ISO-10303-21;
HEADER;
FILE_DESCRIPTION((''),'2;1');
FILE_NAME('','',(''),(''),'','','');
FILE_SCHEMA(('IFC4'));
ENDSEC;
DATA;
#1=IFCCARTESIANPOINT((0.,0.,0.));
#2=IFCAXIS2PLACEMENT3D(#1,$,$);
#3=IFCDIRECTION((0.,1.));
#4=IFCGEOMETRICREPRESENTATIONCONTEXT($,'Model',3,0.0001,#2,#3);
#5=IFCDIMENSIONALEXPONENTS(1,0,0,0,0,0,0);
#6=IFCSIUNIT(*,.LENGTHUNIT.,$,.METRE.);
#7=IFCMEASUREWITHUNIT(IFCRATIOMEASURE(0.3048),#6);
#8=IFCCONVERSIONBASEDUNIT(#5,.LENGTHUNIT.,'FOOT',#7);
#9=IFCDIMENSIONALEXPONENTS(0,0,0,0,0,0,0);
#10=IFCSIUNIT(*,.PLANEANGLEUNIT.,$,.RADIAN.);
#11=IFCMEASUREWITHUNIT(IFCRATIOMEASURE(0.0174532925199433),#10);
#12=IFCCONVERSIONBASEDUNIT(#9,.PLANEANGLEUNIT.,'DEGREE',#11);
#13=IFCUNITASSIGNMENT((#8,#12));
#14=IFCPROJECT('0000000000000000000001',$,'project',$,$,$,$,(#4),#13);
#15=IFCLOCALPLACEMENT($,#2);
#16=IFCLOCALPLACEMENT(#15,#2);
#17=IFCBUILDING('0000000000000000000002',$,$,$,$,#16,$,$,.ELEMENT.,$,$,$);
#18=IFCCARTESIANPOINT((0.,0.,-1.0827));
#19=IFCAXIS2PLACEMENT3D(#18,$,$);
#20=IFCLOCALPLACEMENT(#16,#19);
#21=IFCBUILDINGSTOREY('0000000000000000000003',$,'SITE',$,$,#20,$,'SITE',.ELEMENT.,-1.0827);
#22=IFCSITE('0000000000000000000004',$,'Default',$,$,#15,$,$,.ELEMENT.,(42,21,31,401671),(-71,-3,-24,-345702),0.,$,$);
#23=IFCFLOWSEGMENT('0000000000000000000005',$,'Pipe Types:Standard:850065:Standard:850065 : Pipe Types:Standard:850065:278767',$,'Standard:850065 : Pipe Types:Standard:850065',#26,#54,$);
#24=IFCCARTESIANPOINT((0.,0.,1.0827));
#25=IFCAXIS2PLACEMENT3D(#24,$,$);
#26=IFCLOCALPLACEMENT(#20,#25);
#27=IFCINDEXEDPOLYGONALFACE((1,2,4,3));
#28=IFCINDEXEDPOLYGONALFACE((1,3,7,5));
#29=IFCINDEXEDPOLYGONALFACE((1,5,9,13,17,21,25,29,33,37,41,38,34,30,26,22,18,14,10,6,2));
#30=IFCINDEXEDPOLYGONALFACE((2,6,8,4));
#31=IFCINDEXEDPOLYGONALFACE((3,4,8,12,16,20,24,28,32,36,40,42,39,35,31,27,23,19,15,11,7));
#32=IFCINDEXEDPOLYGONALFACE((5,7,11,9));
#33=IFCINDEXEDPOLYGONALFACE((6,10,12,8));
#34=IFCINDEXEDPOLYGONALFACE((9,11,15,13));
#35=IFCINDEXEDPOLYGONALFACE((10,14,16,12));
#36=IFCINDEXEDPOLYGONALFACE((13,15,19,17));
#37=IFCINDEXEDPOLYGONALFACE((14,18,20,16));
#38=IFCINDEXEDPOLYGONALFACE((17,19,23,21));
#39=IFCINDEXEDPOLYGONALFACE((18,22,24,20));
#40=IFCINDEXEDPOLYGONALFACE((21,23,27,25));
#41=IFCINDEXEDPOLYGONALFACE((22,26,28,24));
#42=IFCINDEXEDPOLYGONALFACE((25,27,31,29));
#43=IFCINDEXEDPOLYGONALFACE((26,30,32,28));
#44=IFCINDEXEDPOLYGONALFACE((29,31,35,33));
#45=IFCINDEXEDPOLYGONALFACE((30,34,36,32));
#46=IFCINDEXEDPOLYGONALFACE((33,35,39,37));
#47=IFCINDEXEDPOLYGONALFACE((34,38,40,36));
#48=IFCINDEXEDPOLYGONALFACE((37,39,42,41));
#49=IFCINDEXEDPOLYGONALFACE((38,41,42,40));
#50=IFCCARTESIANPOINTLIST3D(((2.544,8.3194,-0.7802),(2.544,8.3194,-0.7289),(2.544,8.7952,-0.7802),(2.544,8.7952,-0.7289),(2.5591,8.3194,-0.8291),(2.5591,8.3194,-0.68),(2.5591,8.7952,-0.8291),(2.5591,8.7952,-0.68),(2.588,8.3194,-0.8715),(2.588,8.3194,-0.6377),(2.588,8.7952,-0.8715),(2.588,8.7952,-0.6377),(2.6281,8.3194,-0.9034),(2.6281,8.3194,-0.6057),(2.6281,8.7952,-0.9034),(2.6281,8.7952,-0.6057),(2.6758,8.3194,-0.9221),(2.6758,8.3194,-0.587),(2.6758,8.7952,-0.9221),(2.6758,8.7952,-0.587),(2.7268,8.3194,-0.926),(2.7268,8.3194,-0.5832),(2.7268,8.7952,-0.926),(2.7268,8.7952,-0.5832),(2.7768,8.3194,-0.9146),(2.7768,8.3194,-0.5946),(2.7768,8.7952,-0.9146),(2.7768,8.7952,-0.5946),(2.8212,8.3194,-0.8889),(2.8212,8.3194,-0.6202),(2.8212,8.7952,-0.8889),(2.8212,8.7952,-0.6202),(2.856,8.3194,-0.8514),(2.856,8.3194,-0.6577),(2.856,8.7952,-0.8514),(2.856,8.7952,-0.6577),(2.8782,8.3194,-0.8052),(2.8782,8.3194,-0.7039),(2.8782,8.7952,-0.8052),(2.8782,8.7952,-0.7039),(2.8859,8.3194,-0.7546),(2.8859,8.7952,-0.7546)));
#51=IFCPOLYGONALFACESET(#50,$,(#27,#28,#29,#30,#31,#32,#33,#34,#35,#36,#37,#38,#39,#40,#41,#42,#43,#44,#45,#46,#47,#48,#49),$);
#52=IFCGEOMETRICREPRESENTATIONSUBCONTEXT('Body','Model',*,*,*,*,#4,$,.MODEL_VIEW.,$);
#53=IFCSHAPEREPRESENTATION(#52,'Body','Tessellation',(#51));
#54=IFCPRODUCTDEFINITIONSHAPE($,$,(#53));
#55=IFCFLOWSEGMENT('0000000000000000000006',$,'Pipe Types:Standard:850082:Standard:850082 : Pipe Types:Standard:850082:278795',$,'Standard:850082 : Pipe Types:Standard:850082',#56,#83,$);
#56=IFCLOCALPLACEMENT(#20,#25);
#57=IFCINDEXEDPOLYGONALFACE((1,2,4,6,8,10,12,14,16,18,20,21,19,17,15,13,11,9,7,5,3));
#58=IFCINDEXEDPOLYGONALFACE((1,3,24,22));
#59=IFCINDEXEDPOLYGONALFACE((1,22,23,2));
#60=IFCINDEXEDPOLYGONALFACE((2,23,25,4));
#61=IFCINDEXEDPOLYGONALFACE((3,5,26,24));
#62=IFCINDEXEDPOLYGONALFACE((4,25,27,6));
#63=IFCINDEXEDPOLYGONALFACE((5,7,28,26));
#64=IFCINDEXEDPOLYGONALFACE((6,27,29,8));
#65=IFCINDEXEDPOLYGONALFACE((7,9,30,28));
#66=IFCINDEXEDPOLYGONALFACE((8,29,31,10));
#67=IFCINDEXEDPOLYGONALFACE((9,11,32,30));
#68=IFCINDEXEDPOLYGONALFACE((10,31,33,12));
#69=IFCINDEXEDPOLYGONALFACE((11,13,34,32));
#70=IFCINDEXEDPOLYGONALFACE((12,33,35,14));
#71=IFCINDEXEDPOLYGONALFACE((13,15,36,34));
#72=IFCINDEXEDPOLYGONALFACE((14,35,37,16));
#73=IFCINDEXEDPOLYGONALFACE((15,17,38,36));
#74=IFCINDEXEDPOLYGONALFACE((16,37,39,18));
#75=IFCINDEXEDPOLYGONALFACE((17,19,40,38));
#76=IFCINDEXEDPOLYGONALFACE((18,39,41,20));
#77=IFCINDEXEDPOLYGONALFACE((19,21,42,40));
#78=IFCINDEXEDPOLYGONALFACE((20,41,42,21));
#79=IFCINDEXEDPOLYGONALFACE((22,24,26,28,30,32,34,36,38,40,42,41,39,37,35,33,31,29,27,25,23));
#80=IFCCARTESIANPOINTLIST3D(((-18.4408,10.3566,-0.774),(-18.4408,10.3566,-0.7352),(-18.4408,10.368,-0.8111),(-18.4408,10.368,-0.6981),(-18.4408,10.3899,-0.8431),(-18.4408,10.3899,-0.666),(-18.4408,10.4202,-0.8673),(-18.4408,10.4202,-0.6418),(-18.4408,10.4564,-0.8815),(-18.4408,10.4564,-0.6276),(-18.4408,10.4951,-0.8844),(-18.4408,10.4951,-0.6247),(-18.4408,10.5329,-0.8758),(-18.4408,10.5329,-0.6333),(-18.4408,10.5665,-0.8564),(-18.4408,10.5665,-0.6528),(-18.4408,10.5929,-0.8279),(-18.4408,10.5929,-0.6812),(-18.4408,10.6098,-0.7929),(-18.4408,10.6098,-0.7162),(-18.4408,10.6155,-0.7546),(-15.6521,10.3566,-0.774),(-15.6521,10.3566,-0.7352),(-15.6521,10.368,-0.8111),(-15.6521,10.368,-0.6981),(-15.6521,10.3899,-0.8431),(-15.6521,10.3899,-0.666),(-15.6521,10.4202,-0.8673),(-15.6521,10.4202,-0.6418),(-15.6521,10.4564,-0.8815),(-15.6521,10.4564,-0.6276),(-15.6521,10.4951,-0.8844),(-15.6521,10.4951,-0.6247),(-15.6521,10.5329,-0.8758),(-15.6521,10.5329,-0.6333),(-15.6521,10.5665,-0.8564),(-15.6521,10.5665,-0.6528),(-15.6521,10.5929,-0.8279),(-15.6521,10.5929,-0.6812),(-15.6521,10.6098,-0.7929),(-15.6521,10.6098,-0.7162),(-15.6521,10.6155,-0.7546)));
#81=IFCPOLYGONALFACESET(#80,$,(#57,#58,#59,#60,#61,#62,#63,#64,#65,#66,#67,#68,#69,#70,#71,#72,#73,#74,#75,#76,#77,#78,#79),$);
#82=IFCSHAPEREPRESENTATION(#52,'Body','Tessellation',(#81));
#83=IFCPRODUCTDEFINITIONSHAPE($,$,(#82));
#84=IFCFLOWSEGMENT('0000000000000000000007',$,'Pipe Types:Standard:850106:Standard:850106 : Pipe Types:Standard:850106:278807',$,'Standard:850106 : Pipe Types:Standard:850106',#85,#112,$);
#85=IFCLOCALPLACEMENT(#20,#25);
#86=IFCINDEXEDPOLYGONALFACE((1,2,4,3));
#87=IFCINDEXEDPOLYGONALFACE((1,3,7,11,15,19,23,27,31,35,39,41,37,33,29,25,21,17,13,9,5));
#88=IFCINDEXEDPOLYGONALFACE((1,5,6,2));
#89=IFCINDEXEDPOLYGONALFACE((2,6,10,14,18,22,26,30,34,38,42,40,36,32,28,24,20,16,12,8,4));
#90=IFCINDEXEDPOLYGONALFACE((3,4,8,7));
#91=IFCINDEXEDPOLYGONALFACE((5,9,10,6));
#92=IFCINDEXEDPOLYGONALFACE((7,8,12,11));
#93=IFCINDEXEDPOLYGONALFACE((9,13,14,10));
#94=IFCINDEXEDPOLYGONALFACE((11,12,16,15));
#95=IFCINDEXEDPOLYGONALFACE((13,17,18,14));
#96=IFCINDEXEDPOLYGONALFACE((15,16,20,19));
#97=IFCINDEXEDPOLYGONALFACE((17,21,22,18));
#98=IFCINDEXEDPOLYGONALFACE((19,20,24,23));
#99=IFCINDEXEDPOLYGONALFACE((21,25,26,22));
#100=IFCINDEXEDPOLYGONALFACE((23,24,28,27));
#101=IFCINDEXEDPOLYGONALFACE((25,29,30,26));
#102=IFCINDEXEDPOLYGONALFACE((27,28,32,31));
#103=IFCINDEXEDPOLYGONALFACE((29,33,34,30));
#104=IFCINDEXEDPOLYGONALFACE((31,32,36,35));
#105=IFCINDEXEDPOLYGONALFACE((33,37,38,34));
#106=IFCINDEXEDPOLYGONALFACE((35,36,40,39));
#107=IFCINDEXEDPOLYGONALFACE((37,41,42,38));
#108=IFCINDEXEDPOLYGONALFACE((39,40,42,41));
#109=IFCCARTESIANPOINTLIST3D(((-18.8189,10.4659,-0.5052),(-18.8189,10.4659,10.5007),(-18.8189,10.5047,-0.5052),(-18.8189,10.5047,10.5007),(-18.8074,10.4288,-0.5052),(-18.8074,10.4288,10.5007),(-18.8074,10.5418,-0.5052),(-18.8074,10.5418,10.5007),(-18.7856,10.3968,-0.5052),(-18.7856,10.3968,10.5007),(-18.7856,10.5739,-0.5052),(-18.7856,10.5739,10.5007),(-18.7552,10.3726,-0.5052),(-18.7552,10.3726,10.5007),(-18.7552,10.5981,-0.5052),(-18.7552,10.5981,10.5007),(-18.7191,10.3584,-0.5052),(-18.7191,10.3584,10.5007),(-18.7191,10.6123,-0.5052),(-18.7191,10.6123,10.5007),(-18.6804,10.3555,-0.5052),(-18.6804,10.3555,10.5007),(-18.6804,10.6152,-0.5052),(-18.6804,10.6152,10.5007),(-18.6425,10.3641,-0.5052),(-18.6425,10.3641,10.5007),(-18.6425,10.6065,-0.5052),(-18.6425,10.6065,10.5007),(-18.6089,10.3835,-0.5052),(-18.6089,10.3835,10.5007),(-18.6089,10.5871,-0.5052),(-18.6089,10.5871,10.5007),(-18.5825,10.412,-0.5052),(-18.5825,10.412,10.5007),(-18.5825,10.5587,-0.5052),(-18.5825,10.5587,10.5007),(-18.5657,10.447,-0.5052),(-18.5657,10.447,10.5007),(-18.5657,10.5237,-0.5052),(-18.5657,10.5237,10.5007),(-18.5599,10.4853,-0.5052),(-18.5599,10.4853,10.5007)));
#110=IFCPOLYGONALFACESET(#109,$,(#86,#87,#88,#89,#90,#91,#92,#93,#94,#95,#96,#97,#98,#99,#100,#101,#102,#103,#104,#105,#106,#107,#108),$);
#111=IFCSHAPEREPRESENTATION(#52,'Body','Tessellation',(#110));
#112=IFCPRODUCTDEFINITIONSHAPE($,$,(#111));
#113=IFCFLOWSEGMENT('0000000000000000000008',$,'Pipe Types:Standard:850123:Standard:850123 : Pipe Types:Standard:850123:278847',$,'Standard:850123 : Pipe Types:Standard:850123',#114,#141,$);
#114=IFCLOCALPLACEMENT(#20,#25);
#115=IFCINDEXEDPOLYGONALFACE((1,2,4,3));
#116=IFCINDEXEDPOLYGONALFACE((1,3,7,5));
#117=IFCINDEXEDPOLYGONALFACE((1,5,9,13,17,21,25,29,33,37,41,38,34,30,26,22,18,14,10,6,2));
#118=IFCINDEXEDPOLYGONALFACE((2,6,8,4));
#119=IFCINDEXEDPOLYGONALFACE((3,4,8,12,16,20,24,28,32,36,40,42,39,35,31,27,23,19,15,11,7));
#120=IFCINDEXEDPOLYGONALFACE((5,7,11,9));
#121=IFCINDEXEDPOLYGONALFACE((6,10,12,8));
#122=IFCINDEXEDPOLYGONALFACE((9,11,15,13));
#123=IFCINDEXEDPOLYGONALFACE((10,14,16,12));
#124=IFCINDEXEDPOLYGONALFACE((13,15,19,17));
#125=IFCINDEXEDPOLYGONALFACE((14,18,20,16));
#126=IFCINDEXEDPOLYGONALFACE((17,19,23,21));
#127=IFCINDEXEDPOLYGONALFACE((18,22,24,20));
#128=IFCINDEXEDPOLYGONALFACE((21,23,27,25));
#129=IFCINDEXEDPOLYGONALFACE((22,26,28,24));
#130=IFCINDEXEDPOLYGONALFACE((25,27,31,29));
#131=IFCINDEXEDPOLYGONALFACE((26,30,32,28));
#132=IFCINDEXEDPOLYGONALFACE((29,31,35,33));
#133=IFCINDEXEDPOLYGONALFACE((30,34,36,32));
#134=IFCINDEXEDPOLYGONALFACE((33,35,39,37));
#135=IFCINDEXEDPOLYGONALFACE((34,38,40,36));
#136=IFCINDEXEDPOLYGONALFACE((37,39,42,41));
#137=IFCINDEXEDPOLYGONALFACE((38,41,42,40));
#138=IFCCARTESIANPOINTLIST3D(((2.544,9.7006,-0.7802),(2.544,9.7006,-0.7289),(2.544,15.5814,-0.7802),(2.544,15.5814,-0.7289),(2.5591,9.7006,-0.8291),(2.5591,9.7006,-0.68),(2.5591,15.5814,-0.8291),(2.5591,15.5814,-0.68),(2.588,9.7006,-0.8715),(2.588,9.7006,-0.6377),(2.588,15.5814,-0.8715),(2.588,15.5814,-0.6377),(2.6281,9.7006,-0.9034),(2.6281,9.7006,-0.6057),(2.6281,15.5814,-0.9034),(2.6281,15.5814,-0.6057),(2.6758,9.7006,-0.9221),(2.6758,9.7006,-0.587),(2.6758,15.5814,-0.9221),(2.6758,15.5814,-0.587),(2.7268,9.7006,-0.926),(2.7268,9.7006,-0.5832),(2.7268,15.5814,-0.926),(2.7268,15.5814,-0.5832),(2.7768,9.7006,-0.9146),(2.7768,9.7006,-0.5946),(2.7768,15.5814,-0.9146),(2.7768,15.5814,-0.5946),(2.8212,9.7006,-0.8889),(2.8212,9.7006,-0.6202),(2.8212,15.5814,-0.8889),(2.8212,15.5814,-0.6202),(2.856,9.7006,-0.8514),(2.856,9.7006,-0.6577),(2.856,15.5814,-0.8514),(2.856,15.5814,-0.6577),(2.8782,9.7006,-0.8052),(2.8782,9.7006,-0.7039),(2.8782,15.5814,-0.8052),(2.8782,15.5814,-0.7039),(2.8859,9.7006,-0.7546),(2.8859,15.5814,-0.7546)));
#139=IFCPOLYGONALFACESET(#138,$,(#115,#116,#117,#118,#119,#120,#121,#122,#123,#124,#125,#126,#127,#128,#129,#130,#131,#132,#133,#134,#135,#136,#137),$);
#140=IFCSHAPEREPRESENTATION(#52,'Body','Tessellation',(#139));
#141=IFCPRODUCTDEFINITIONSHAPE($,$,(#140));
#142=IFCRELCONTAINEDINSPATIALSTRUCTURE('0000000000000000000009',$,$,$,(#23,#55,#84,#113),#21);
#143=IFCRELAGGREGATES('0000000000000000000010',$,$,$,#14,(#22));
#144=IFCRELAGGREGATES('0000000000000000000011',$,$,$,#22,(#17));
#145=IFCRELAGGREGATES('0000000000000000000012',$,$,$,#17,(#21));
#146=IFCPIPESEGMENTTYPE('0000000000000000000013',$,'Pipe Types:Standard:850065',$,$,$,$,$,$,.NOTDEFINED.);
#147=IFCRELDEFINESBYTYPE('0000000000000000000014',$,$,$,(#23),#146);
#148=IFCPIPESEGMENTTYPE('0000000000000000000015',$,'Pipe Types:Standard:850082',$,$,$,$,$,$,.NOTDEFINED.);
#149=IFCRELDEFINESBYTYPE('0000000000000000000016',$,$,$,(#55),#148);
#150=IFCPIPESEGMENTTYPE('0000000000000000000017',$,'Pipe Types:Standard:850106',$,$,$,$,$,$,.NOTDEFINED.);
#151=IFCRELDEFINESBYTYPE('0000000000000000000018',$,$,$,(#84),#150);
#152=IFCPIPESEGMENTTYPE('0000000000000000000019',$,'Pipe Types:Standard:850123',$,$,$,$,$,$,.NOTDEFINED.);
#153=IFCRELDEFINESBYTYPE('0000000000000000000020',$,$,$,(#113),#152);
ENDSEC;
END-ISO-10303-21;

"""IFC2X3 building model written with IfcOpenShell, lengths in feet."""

from ifc_helpers import new_model, entity, si_unit, converted_unit, direction, frame, frame_2d, origin, origin_2d_with_axis, place, context, subcontext, project, spatial, circle, extrude, source, transform, mapped, type_object, type_shapes, element, save


model = new_model("IFC2X3")

# Units and contexts
model_context = context("Model", 3, precision=0.0001, world=origin(), true_north=direction((0.0, 1.0)))
body_context = subcontext(model_context, "Body", "Model", "MODEL_VIEW")
ifc_project = project(units=[converted_unit("LENGTHUNIT", "FOOT", entity("IfcRatioMeasure", 0.3048), si_unit("LENGTHUNIT", "METRE"), dimensions=[1, 0, 0, 0, 0, 0, 0]), converted_unit("PLANEANGLEUNIT", "DEGREE", entity("IfcRatioMeasure", 0.0174532925199433), si_unit("PLANEANGLEUNIT", "RADIAN"), dimensions=[0, 0, 0, 0, 0, 0, 0])], contexts=[model_context])

# Site, building, storey
site_placement = place(None, origin())
site = spatial("IfcSite", under=ifc_project, at=site_placement, Name="Default", CompositionType="ELEMENT", RefLatitude=(42, 21, 31, 401671), RefLongitude=(-71, -3, -24, -345702), RefElevation=0.0)
building_placement = place(site_placement, origin())
building = spatial("IfcBuilding", under=site, at=building_placement, CompositionType="ELEMENT")
storey_placement = place(building_placement, frame((0.0, 0.0, -1.0827)))
storey = spatial("IfcBuildingStorey", under=building, at=storey_placement, Name="SITE", LongName="SITE", CompositionType="ELEMENT", Elevation=-1.0827)

# Flow segments
pipe_segment_type_1 = type_object("IfcPipeSegmentType", Name="Pipe Types:Standard:850065", PredefinedType="NOTDEFINED")
shared_shape_1 = source(origin(), body_context, "Body", "SweptSolid", [
    extrude(circle(Radius=0.1719, at=frame_2d((0.0, 0.0), x_axis=(1.0, 0.0))), frame((2.714, 8.3194, -0.7546), z_axis=(0.0, 1.0, 0.0), x_axis=(1.0, 0.0, 0.0)), (0.0, 0.0, 1.0), 0.4759),
])
type_shapes(pipe_segment_type_1, [shared_shape_1])
flow_segment_1_placement = place(storey_placement, frame((0.0, 0.0, 1.0827)))
element("IfcFlowSegment", 1, at=flow_segment_1_placement, inside=storey, type_object=pipe_segment_type_1, Name="Pipe Types:Standard:850065:Standard:850065 : Pipe Types:Standard:850065:278767", ObjectType="Standard:850065 : Pipe Types:Standard:850065", context=body_context, shape_type="MappedRepresentation", body=[
    mapped(shared_shape_1, transform((0.0, 0.0, 0.0), scale=1.0)),
])
pipe_segment_type_2 = type_object("IfcPipeSegmentType", Name="Pipe Types:Standard:850082", PredefinedType="NOTDEFINED")
shared_shape_2 = source(origin(), body_context, "Body", "SweptSolid", [
    extrude(circle(Radius=0.1302, at=frame_2d((0.0, 0.0), x_axis=(1.0, 0.0))), frame((-18.4408, 10.4853, -0.7546), z_axis=(1.0, 0.0, 0.0), x_axis=(0.0, 1.0, 0.0)), (0.0, 0.0, 1.0), 2.7887),
])
type_shapes(pipe_segment_type_2, [shared_shape_2])
flow_segment_2_placement = place(storey_placement, frame((0.0, 0.0, 1.0827)))
element("IfcFlowSegment", 2, at=flow_segment_2_placement, inside=storey, type_object=pipe_segment_type_2, Name="Pipe Types:Standard:850082:Standard:850082 : Pipe Types:Standard:850082:278795", ObjectType="Standard:850082 : Pipe Types:Standard:850082", context=body_context, shape_type="MappedRepresentation", body=[
    mapped(shared_shape_2, transform((0.0, 0.0, 0.0), scale=1.0)),
])
pipe_segment_type_3 = type_object("IfcPipeSegmentType", Name="Pipe Types:Standard:850106", PredefinedType="NOTDEFINED")
shared_shape_3 = source(origin(), body_context, "Body", "SweptSolid", [
    extrude(circle(Radius=0.1302, at=origin_2d_with_axis()), frame((-18.6901, 10.4853, -0.5052)), (0.0, 0.0, 1.0), 11.0059),
])
type_shapes(pipe_segment_type_3, [shared_shape_3])
flow_segment_3_placement = place(storey_placement, frame((0.0, 0.0, 1.0827)))
element("IfcFlowSegment", 3, at=flow_segment_3_placement, inside=storey, type_object=pipe_segment_type_3, Name="Pipe Types:Standard:850106:Standard:850106 : Pipe Types:Standard:850106:278807", ObjectType="Standard:850106 : Pipe Types:Standard:850106", context=body_context, shape_type="MappedRepresentation", body=[
    mapped(shared_shape_3, transform((0.0, 0.0, 0.0), scale=1.0)),
])
pipe_segment_type_4 = type_object("IfcPipeSegmentType", Name="Pipe Types:Standard:850123", PredefinedType="NOTDEFINED")
shared_shape_4 = source(origin(), body_context, "Body", "SweptSolid", [
    extrude(circle(Radius=0.1719, at=frame_2d((0.0, 0.0), x_axis=(1.0, 0.0))), frame((2.714, 9.7006, -0.7546), z_axis=(0.0, 1.0, 0.0), x_axis=(1.0, 0.0, 0.0)), (0.0, 0.0, 1.0), 5.8809),
])
type_shapes(pipe_segment_type_4, [shared_shape_4])
flow_segment_4_placement = place(storey_placement, frame((0.0, 0.0, 1.0827)))
element("IfcFlowSegment", 4, at=flow_segment_4_placement, inside=storey, type_object=pipe_segment_type_4, Name="Pipe Types:Standard:850123:Standard:850123 : Pipe Types:Standard:850123:278847", ObjectType="Standard:850123 : Pipe Types:Standard:850123", context=body_context, shape_type="MappedRepresentation", body=[
    mapped(shared_shape_4, transform((0.0, 0.0, 0.0), scale=1.0)),
])

save(model, "model.ifc")
